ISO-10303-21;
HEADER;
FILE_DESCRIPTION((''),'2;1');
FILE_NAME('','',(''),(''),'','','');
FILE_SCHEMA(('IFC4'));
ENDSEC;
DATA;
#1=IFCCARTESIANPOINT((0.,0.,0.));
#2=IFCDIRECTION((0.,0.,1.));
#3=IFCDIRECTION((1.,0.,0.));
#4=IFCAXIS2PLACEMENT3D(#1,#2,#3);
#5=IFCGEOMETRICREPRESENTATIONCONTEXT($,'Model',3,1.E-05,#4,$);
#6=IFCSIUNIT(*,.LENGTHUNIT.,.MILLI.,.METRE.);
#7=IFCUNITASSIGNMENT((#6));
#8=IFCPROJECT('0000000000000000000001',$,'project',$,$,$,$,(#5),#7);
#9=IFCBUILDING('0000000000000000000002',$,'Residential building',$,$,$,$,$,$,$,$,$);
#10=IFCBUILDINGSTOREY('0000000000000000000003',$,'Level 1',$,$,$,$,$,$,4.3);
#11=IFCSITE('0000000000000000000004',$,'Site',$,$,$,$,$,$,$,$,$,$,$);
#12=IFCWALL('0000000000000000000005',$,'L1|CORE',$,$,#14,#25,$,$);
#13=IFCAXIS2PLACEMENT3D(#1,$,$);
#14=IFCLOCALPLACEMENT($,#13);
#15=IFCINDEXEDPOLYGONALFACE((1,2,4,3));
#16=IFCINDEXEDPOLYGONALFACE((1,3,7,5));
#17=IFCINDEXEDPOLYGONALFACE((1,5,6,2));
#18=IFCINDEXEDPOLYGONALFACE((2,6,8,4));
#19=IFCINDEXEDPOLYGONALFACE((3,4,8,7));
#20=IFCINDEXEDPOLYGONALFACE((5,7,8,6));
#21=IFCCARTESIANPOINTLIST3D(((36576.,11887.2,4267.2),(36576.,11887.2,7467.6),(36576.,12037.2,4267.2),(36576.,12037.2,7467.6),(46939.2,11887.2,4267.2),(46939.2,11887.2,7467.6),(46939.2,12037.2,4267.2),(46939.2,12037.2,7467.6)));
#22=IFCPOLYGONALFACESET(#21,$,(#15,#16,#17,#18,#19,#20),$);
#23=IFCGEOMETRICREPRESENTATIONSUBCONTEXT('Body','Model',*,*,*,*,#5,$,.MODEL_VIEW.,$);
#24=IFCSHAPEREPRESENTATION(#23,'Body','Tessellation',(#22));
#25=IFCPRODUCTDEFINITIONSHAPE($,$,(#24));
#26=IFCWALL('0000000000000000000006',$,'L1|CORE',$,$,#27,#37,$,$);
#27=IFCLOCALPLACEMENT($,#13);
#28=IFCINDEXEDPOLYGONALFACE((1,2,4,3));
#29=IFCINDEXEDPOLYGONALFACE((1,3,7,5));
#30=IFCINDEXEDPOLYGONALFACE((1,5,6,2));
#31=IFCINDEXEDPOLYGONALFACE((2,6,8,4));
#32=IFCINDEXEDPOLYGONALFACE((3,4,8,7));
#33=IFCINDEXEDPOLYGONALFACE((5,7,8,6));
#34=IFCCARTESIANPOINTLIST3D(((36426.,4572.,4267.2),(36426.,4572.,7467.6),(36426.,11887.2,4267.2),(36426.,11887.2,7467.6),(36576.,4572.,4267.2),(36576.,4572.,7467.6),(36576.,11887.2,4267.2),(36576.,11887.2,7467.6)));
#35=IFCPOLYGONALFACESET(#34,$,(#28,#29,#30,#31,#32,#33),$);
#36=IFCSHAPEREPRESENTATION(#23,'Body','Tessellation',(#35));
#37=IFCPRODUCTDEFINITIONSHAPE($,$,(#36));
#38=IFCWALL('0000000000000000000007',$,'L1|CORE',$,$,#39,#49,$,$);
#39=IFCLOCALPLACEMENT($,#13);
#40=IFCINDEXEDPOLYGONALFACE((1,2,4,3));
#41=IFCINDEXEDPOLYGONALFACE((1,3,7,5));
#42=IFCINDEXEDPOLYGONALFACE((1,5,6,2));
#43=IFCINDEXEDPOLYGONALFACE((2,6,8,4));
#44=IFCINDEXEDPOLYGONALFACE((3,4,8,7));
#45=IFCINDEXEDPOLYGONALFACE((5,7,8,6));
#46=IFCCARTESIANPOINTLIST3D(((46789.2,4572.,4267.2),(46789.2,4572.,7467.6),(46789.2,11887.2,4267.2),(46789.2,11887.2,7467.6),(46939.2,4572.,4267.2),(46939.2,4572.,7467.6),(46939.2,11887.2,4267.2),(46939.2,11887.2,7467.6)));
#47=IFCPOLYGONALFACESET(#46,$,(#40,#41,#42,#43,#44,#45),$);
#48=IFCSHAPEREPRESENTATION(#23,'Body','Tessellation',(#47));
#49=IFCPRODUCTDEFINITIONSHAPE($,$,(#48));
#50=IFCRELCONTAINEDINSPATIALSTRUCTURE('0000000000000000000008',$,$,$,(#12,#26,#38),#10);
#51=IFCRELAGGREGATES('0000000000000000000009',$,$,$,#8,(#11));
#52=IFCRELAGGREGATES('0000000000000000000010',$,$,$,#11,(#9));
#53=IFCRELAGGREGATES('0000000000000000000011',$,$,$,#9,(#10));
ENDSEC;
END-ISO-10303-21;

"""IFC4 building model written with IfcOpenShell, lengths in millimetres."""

from ifc_helpers import new_model, si_unit, frame, origin_with_axes, place, context, subcontext, project, spatial, indexed_curve, outline, extrude, element, save


model = new_model("IFC4")

# Units and contexts
model_context = context("Model", 3, precision=1e-05, world=origin_with_axes())
body_context = subcontext(model_context, "Body", "Model", "MODEL_VIEW")
ifc_project = project(units=[si_unit("LENGTHUNIT", "METRE", prefix="MILLI")], contexts=[model_context])

# Site, building, storey
site = spatial("IfcSite", under=ifc_project, Name="Site")
building = spatial("IfcBuilding", under=site, Name="Residential building")
storey = spatial("IfcBuildingStorey", under=building, Name="Level 1", Elevation=4.3)

# Walls
for number, where, z_axis, x_axis, name in (
    (1, (36576.0, 11887.2, 4267.2), (0.0, 0.0, 1.0), (1.0, 0.0, 0.0), "L1|CORE"),
):
    element("IfcWall", number, at=place(None, frame(where, z_axis=z_axis, x_axis=x_axis)), inside=storey, Name=name, context=body_context, shape_type="SweptSolid", body=[
        extrude(outline(indexed_curve([(0.0, 0.0), (0.0, 150.0), (10363.2, 150.0), (10363.2, 0.0), (0.0, 0.0)], self_intersect=False)), origin_with_axes(), (0.0, 0.0, 1.0), 3200.4),
    ])
for number, where, z_axis, x_axis, name in (
    (2, (36576.0, 4572.0, 4267.2), (0.0, 0.0, 1.0), (0.0, 1.0, 0.0), "L1|CORE"),
    (3, (46939.2, 4572.0, 4267.2), (0.0, 0.0, 1.0), (0.0, 1.0, 0.0), "L1|CORE"),
):
    element("IfcWall", number, at=place(None, frame(where, z_axis=z_axis, x_axis=x_axis)), inside=storey, Name=name, context=body_context, shape_type="SweptSolid", body=[
        extrude(outline(indexed_curve([(0.0, 0.0), (0.0, 150.0), (7315.2, 150.0), (7315.2, 0.0), (0.0, 0.0)], self_intersect=False)), origin_with_axes(), (0.0, 0.0, 1.0), 3200.4),
    ])

save(model, "model.ifc")
